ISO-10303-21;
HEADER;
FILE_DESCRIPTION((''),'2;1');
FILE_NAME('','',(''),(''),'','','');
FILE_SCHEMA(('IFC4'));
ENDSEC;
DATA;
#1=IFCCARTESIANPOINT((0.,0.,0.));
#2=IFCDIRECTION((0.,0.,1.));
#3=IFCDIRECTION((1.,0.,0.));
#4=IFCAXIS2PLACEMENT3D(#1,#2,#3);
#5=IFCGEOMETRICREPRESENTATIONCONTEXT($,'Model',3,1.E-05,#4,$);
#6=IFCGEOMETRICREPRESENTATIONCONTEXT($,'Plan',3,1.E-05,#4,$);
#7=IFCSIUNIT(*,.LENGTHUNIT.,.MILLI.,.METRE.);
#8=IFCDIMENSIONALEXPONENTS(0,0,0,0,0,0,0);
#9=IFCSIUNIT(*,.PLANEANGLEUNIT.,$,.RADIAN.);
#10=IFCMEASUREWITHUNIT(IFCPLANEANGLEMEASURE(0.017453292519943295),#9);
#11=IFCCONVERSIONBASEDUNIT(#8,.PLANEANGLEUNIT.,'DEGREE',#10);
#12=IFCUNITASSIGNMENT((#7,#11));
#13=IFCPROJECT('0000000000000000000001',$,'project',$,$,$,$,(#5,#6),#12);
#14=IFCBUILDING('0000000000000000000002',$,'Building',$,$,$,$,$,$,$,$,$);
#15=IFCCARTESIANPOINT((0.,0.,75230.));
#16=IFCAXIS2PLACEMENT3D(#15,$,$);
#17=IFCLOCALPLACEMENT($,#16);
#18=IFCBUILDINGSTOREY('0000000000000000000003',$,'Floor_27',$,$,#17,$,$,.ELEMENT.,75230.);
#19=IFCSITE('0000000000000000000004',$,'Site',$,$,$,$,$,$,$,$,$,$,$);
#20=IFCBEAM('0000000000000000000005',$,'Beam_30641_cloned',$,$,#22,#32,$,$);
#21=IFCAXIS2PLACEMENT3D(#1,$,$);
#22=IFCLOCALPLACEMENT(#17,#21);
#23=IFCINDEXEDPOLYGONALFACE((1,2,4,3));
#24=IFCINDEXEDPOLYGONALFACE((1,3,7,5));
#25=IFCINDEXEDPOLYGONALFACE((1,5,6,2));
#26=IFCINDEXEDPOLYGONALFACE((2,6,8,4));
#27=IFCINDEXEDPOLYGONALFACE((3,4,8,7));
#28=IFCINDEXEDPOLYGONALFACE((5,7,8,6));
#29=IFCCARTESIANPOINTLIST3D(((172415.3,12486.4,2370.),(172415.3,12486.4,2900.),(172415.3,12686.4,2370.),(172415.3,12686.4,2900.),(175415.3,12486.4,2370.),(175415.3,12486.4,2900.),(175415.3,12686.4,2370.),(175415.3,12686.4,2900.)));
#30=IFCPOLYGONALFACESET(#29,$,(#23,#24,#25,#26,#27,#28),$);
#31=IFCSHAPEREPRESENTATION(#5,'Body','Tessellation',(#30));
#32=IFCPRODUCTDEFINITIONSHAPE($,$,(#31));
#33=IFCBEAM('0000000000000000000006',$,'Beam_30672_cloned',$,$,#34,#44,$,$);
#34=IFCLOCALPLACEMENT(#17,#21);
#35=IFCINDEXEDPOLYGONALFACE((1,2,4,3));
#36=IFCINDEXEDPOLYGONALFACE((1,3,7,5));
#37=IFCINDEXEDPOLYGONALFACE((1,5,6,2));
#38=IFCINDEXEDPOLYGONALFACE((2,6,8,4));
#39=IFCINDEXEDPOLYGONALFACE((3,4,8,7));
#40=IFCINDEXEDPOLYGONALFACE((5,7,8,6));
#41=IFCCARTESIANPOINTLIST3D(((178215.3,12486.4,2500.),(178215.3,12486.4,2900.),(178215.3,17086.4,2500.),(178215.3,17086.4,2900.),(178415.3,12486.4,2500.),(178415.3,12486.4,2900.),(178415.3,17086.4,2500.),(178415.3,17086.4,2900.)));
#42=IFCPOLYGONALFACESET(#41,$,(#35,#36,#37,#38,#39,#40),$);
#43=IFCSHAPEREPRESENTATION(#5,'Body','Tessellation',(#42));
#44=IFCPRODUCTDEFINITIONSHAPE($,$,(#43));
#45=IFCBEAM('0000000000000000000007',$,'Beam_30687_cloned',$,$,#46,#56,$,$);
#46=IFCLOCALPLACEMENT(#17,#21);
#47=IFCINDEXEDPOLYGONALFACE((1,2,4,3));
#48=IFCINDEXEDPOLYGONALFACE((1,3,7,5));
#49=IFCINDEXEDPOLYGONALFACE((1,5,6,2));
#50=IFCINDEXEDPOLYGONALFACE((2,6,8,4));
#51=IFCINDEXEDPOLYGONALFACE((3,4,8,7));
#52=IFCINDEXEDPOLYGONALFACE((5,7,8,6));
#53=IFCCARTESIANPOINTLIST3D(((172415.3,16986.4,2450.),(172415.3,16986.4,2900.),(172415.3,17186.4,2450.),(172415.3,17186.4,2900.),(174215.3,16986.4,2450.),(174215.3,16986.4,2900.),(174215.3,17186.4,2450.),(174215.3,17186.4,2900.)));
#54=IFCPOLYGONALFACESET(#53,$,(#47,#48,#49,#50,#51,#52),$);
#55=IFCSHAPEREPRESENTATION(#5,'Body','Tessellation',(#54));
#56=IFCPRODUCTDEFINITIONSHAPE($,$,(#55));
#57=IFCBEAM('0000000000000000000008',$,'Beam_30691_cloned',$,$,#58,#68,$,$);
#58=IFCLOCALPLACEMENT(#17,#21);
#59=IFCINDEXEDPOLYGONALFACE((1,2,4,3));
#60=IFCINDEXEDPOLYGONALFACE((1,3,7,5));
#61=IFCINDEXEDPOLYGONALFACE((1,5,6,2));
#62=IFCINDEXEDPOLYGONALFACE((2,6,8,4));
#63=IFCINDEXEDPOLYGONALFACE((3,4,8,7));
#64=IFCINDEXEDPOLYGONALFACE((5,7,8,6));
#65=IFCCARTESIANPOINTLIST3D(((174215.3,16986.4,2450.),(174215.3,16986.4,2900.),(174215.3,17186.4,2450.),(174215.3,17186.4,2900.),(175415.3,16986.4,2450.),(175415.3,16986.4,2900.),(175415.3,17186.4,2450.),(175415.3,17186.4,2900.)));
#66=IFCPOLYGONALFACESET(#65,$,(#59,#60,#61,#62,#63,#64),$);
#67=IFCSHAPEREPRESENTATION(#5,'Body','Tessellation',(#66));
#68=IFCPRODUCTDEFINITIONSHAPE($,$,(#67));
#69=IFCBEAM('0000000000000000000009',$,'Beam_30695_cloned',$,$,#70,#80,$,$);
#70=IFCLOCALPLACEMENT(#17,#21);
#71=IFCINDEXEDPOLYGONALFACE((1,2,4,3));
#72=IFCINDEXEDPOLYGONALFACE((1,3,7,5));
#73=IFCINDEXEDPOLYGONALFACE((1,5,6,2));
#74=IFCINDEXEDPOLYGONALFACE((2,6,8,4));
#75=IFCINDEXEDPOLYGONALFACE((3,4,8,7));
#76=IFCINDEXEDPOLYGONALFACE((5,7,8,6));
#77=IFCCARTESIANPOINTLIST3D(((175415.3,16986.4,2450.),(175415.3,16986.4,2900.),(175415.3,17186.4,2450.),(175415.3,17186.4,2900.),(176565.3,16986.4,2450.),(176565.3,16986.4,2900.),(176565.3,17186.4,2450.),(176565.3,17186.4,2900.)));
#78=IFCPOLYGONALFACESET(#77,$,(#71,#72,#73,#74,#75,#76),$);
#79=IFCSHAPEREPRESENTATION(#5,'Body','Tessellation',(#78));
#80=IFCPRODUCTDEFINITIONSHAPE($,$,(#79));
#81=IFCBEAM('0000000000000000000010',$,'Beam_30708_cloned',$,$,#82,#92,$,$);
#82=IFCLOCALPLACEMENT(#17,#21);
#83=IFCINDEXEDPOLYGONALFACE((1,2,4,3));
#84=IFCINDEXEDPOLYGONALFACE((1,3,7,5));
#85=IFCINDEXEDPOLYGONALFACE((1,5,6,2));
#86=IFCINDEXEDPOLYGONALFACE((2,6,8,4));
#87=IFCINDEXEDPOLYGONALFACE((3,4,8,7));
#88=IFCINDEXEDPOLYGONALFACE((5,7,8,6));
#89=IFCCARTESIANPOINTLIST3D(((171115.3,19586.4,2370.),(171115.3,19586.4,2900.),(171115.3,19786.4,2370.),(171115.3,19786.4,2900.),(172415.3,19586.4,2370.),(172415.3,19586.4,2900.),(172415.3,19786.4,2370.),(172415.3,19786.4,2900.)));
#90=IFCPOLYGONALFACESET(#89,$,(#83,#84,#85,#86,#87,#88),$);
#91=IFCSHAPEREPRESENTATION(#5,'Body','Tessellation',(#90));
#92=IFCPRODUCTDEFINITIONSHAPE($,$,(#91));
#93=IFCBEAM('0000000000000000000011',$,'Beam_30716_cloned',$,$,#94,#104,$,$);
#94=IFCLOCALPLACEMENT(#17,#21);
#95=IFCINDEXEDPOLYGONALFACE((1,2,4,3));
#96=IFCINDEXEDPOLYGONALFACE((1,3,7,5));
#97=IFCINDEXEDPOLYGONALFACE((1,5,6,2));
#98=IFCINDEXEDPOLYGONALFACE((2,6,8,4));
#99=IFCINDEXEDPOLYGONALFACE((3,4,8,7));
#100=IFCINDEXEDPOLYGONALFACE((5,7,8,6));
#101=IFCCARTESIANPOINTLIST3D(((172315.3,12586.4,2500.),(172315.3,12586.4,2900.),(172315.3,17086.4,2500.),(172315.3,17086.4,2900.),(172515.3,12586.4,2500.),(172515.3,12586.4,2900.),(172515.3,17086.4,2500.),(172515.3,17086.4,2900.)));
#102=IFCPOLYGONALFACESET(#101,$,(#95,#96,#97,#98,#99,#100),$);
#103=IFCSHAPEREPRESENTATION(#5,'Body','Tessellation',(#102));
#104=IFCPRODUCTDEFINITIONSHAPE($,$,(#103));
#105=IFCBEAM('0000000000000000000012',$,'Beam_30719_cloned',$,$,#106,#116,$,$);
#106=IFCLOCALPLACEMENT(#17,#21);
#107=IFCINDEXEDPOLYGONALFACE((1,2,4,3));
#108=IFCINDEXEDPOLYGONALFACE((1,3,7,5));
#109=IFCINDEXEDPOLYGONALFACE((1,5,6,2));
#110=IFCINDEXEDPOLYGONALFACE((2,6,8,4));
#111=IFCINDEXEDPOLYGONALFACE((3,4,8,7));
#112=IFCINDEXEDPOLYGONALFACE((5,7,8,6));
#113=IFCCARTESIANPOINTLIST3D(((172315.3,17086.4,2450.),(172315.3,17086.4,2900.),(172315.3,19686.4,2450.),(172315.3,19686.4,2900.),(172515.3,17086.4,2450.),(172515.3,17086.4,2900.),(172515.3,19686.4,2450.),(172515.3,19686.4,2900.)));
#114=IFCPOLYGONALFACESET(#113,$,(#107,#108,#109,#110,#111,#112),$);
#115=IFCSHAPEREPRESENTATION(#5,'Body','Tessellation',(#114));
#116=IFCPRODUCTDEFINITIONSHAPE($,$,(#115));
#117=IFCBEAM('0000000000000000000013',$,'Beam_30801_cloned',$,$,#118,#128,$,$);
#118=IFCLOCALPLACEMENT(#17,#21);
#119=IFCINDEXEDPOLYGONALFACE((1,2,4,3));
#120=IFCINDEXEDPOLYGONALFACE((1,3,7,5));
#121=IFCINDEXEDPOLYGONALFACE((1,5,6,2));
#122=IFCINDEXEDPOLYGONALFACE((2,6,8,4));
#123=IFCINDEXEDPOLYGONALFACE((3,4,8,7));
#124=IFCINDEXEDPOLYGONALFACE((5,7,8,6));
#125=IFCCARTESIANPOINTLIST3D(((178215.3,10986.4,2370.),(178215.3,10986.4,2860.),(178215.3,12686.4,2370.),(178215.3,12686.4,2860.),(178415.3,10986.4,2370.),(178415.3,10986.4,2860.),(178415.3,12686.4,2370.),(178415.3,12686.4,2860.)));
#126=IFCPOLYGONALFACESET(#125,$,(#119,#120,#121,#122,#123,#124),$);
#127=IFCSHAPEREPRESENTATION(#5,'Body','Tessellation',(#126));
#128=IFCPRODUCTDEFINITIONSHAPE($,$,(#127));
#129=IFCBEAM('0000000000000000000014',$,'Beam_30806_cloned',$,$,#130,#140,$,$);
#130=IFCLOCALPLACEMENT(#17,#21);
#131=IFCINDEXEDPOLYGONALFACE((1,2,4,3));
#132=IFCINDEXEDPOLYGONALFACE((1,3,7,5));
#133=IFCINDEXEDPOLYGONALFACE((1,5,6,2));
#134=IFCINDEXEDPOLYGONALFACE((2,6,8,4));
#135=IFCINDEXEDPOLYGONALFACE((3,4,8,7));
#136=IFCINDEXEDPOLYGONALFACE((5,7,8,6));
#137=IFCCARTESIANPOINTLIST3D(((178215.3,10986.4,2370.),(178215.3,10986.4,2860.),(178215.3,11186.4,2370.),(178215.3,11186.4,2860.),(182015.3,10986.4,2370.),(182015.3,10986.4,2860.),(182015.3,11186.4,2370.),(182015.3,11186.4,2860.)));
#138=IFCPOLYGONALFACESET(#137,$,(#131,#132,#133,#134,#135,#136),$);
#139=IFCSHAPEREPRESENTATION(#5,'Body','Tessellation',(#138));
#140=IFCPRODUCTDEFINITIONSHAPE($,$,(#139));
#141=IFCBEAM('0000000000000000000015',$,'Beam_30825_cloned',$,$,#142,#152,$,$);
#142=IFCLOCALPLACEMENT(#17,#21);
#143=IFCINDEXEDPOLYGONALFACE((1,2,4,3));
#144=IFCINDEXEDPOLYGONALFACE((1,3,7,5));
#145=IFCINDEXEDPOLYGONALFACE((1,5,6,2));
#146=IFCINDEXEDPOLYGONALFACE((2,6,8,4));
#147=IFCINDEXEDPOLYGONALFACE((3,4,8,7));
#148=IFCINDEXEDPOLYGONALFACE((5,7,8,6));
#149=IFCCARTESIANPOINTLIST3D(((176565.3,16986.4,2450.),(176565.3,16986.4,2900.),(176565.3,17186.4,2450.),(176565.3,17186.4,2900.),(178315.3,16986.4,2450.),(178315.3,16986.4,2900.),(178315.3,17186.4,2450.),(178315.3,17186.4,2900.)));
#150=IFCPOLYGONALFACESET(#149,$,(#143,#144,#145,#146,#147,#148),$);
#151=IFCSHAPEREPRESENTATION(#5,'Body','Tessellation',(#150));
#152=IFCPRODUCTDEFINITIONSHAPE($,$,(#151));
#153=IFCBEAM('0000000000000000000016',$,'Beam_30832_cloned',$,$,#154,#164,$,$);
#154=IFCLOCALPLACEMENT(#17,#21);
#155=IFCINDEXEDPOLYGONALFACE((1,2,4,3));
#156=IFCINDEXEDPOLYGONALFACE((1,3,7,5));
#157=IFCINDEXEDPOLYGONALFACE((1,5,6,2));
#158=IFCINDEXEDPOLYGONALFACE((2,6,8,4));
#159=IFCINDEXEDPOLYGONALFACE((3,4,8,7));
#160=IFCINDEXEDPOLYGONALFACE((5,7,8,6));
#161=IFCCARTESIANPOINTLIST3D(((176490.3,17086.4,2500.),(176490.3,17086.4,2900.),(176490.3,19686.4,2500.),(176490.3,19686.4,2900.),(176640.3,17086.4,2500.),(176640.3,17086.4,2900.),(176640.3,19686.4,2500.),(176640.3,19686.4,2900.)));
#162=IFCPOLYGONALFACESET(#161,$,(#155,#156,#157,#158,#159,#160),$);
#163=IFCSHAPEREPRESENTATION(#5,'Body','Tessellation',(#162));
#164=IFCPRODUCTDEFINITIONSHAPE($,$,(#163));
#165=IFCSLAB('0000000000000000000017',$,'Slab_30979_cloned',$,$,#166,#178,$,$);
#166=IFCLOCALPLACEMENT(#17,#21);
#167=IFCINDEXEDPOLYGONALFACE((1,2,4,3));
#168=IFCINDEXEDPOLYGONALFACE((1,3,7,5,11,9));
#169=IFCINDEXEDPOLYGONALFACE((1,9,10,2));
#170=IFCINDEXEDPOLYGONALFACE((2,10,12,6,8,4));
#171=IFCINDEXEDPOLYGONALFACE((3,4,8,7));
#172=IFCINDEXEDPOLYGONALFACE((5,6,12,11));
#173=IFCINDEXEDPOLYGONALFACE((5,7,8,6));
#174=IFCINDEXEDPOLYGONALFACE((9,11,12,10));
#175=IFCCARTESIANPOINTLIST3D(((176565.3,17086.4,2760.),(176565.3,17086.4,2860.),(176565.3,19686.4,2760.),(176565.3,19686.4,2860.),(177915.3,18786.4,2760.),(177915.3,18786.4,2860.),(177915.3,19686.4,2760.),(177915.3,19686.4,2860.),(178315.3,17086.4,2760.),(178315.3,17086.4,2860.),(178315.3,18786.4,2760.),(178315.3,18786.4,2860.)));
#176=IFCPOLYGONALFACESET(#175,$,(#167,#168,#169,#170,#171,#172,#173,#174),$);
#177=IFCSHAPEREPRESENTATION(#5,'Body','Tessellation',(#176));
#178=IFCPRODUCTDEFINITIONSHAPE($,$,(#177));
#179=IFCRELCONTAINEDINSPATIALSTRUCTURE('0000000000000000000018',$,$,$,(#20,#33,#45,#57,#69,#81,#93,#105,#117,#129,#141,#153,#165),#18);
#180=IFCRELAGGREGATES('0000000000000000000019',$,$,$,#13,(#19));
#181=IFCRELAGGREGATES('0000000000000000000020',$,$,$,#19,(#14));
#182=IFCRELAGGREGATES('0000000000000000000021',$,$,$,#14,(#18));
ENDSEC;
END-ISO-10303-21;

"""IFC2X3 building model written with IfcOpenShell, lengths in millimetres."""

from ifc_helpers import new_model, entity, si_unit, converted_unit, frame, origin_with_axes, origin_2d, place, context, project, spatial, polyline, rectangle, outline, extrude, source, transform, mapped, element, save


model = new_model("IFC2X3")

# Units and contexts
model_context = context("Model", 3, precision=1e-05, world=origin_with_axes())
plan_context = context("Plan", 3, precision=1e-05, world=origin_with_axes())
ifc_project = project(units=[si_unit("LENGTHUNIT", "METRE", prefix="MILLI"), converted_unit("PLANEANGLEUNIT", "DEGREE", entity("IfcPlaneAngleMeasure", 0.017453292519943295), si_unit("PLANEANGLEUNIT", "RADIAN"), dimensions=[0, 0, 0, 0, 0, 0, 0])], contexts=[model_context, plan_context])

# Site, building, storey
site = spatial("IfcSite", under=ifc_project, Name="Site")
building = spatial("IfcBuilding", under=site, Name="Building")
storey_placement = place(None, frame((0.0, 0.0, 75230.0)))
storey = spatial("IfcBuildingStorey", under=building, at=storey_placement, Name="Floor_27", CompositionType="ELEMENT", Elevation=75230.0)

# Beams
shared_shape_1 = source(origin_with_axes(), model_context, "Body", "SweptSolid", [
    extrude(rectangle(XDim=200.0, YDim=530.0, at=origin_2d()), origin_with_axes(), (0.0, 0.0, 1.0), 3000.0),
])
beam_1_placement = place(storey_placement, frame((172415.3, 12586.4, 2635.0), z_axis=(2999.999693, 0.0, 0.0), x_axis=(0.0, -2999.999693, 0.0)))
element("IfcBeam", 1, at=beam_1_placement, inside=storey, Name="Beam_30641_cloned", context=model_context, shape_type="MappedRepresentation", body=[
    mapped(shared_shape_1, transform((0.0, 0.0, 0.0), x_axis=(1.0, 0.0, 0.0), y_axis=(0.0, 1.0, 0.0), z_axis=(0.0, 0.0, 1.0), scale=1.0)),
])
shared_shape_2 = source(origin_with_axes(), model_context, "Body", "SweptSolid", [
    extrude(rectangle(XDim=200.0, YDim=400.0, at=origin_2d()), origin_with_axes(), (0.0, 0.0, 1.0), 4600.0),
])
beam_2_placement = place(storey_placement, frame((178315.3, 12486.4, 2700.0), z_axis=(-0.000341, 4600.030689, 0.0), x_axis=(4600.030689, 0.000341, 0.0)))
element("IfcBeam", 2, at=beam_2_placement, inside=storey, Name="Beam_30672_cloned", context=model_context, shape_type="MappedRepresentation", body=[
    mapped(shared_shape_2, transform((0.0, 0.0, 0.0), x_axis=(1.0, 0.0, 0.0), y_axis=(0.0, 1.0, 0.0), z_axis=(0.0, 0.0, 1.0), scale=1.0)),
])
shared_shape_3 = source(origin_with_axes(), model_context, "Body", "SweptSolid", [
    extrude(rectangle(XDim=200.0, YDim=450.0, at=origin_2d()), origin_with_axes(), (0.0, 0.0, 1.0), 1800.0),
])
beam_3_placement = place(storey_placement, frame((172415.3, 17086.4, 2675.0), z_axis=(1800.000018, -0.000024, 0.0), x_axis=(-0.000024, -1800.000018, 0.0)))
element("IfcBeam", 3, at=beam_3_placement, inside=storey, Name="Beam_30687_cloned", context=model_context, shape_type="MappedRepresentation", body=[
    mapped(shared_shape_3, transform((0.0, 0.0, 0.0), x_axis=(1.0, 0.0, 0.0), y_axis=(0.0, 1.0, 0.0), z_axis=(0.0, 0.0, 1.0), scale=1.0)),
])
shared_shape_4 = source(origin_with_axes(), model_context, "Body", "SweptSolid", [
    extrude(rectangle(XDim=200.0, YDim=450.0, at=origin_2d()), origin_with_axes(), (0.0, 0.0, 1.0), 1200.0),
])
beam_4_placement = place(storey_placement, frame((174215.3, 17086.4, 2675.0), z_axis=(1199.999669, 0.000037, 0.0), x_axis=(0.000037, -1199.999669, 0.0)))
element("IfcBeam", 4, at=beam_4_placement, inside=storey, Name="Beam_30691_cloned", context=model_context, shape_type="MappedRepresentation", body=[
    mapped(shared_shape_4, transform((0.0, 0.0, 0.0), x_axis=(1.0, 0.0, 0.0), y_axis=(0.0, 1.0, 0.0), z_axis=(0.0, 0.0, 1.0), scale=1.0)),
])
shared_shape_5 = source(origin_with_axes(), model_context, "Body", "SweptSolid", [
    extrude(rectangle(XDim=200.0, YDim=450.0, at=origin_2d()), origin_with_axes(), (0.0, 0.0, 1.0), 1150.0),
])
beam_5_placement = place(storey_placement, frame((175415.3, 17086.4, 2675.0), z_axis=(1149.999861, 0.000005, 0.0), x_axis=(0.000005, -1149.999861, 0.0)))
element("IfcBeam", 5, at=beam_5_placement, inside=storey, Name="Beam_30695_cloned", context=model_context, shape_type="MappedRepresentation", body=[
    mapped(shared_shape_5, transform((0.0, 0.0, 0.0), x_axis=(1.0, 0.0, 0.0), y_axis=(0.0, 1.0, 0.0), z_axis=(0.0, 0.0, 1.0), scale=1.0)),
])
shared_shape_6 = source(origin_with_axes(), model_context, "Body", "SweptSolid", [
    extrude(rectangle(XDim=200.0, YDim=530.0, at=origin_2d()), origin_with_axes(), (0.0, 0.0, 1.0), 1300.0),
])
beam_6_placement = place(storey_placement, frame((171115.3, 19686.4, 2635.0), z_axis=(1300.000018, 0.0, 0.0), x_axis=(0.0, -1300.000018, 0.0)))
element("IfcBeam", 6, at=beam_6_placement, inside=storey, Name="Beam_30708_cloned", context=model_context, shape_type="MappedRepresentation", body=[
    mapped(shared_shape_6, transform((0.0, 0.0, 0.0), x_axis=(1.0, 0.0, 0.0), y_axis=(0.0, 1.0, 0.0), z_axis=(0.0, 0.0, 1.0), scale=1.0)),
])
shared_shape_7 = source(origin_with_axes(), model_context, "Body", "SweptSolid", [
    extrude(rectangle(XDim=200.0, YDim=400.0, at=origin_2d()), origin_with_axes(), (0.0, 0.0, 1.0), 4500.0),
])
beam_7_placement = place(storey_placement, frame((172415.3, 12586.4, 2700.0), z_axis=(0.0, 4500.030665, 0.0), x_axis=(4500.030665, 0.0, 0.0)))
element("IfcBeam", 7, at=beam_7_placement, inside=storey, Name="Beam_30716_cloned", context=model_context, shape_type="MappedRepresentation", body=[
    mapped(shared_shape_7, transform((0.0, 0.0, 0.0), x_axis=(1.0, 0.0, 0.0), y_axis=(0.0, 1.0, 0.0), z_axis=(0.0, 0.0, 1.0), scale=1.0)),
])
shared_shape_8 = source(origin_with_axes(), model_context, "Body", "SweptSolid", [
    extrude(rectangle(XDim=200.0, YDim=450.0, at=origin_2d()), origin_with_axes(), (0.0, 0.0, 1.0), 2600.0),
])
beam_8_placement = place(storey_placement, frame((172415.3, 17086.4, 2675.0), z_axis=(0.0, 2599.990188, 0.0), x_axis=(2599.990188, 0.0, 0.0)))
element("IfcBeam", 8, at=beam_8_placement, inside=storey, Name="Beam_30719_cloned", context=model_context, shape_type="MappedRepresentation", body=[
    mapped(shared_shape_8, transform((0.0, 0.0, 0.0), x_axis=(1.0, 0.0, 0.0), y_axis=(0.0, 1.0, 0.0), z_axis=(0.0, 0.0, 1.0), scale=1.0)),
])
shared_shape_9 = source(origin_with_axes(), model_context, "Body", "SweptSolid", [
    extrude(rectangle(XDim=200.0, YDim=490.0, at=origin_2d()), origin_with_axes(), (0.0, 0.0, 1.0), 1700.0),
])
beam_9_placement = place(storey_placement, frame((178315.3, 10986.4, 2615.0), z_axis=(0.0, 1700.0, 0.0), x_axis=(1700.0, 0.0, 0.0)))
element("IfcBeam", 9, at=beam_9_placement, inside=storey, Name="Beam_30801_cloned", context=model_context, shape_type="MappedRepresentation", body=[
    mapped(shared_shape_9, transform((0.0, 0.0, 0.0), x_axis=(1.0, 0.0, 0.0), y_axis=(0.0, 1.0, 0.0), z_axis=(0.0, 0.0, 1.0), scale=1.0)),
])
shared_shape_10 = source(origin_with_axes(), model_context, "Body", "SweptSolid", [
    extrude(rectangle(XDim=200.0, YDim=490.0, at=origin_2d()), origin_with_axes(), (0.0, 0.0, 1.0), 3800.0),
])
beam_10_placement = place(storey_placement, frame((178215.3, 11086.4, 2615.0), z_axis=(3800.00001, 0.0, 0.0), x_axis=(0.0, -3800.00001, 0.0)))
element("IfcBeam", 10, at=beam_10_placement, inside=storey, Name="Beam_30806_cloned", context=model_context, shape_type="MappedRepresentation", body=[
    mapped(shared_shape_10, transform((0.0, 0.0, 0.0), x_axis=(1.0, 0.0, 0.0), y_axis=(0.0, 1.0, 0.0), z_axis=(0.0, 0.0, 1.0), scale=1.0)),
])
shared_shape_11 = source(origin_with_axes(), model_context, "Body", "SweptSolid", [
    extrude(rectangle(XDim=200.0, YDim=450.0, at=origin_2d()), origin_with_axes(), (0.0, 0.0, 1.0), 1750.0),
])
beam_11_placement = place(storey_placement, frame((176565.3, 17086.4, 2675.0), z_axis=(1750.0, 0.000007, 0.0), x_axis=(0.000007, -1750.0, 0.0)))
element("IfcBeam", 11, at=beam_11_placement, inside=storey, Name="Beam_30825_cloned", context=model_context, shape_type="MappedRepresentation", body=[
    mapped(shared_shape_11, transform((0.0, 0.0, 0.0), x_axis=(1.0, 0.0, 0.0), y_axis=(0.0, 1.0, 0.0), z_axis=(0.0, 0.0, 1.0), scale=1.0)),
])
shared_shape_12 = source(origin_with_axes(), model_context, "Body", "SweptSolid", [
    extrude(rectangle(XDim=150.0, YDim=400.0, at=origin_2d()), origin_with_axes(), (0.0, 0.0, 1.0), 2600.0),
])
beam_12_placement = place(storey_placement, frame((176565.3, 17086.4, 2700.0), z_axis=(0.0, 2599.990171, 0.0), x_axis=(2599.990171, 0.0, 0.0)))
element("IfcBeam", 12, at=beam_12_placement, inside=storey, Name="Beam_30832_cloned", context=model_context, shape_type="MappedRepresentation", body=[
    mapped(shared_shape_12, transform((0.0, 0.0, 0.0), x_axis=(1.0, 0.0, 0.0), y_axis=(0.0, 1.0, 0.0), z_axis=(0.0, 0.0, 1.0), scale=1.0)),
])

# Slab
shared_shape_13 = source(origin_with_axes(), model_context, "Body", "SweptSolid", [
    extrude(outline(polyline([(0.0, 0.0), (1350.0, 0.0), (1350.0, 2600.0), (-400.0, 2600.0), (-400.0, 900.0), (0.0, 900.0)])), origin_with_axes(), (0.0, 0.0, 1.0), 100.0),
])
slab_1_placement = place(storey_placement, frame((177915.3, 19686.4, 2760.0), z_axis=(0.0, 0.0, 1.0), x_axis=(-1350.0, 0.0, 0.0)))
element("IfcSlab", 13, at=slab_1_placement, inside=storey, Name="Slab_30979_cloned", context=model_context, shape_type="MappedRepresentation", body=[
    mapped(shared_shape_13, transform((0.0, 0.0, 0.0), x_axis=(1.0, 0.0, 0.0), y_axis=(0.0, 1.0, 0.0), z_axis=(0.0, 0.0, 1.0), scale=1.0)),
])

save(model, "model.ifc")
